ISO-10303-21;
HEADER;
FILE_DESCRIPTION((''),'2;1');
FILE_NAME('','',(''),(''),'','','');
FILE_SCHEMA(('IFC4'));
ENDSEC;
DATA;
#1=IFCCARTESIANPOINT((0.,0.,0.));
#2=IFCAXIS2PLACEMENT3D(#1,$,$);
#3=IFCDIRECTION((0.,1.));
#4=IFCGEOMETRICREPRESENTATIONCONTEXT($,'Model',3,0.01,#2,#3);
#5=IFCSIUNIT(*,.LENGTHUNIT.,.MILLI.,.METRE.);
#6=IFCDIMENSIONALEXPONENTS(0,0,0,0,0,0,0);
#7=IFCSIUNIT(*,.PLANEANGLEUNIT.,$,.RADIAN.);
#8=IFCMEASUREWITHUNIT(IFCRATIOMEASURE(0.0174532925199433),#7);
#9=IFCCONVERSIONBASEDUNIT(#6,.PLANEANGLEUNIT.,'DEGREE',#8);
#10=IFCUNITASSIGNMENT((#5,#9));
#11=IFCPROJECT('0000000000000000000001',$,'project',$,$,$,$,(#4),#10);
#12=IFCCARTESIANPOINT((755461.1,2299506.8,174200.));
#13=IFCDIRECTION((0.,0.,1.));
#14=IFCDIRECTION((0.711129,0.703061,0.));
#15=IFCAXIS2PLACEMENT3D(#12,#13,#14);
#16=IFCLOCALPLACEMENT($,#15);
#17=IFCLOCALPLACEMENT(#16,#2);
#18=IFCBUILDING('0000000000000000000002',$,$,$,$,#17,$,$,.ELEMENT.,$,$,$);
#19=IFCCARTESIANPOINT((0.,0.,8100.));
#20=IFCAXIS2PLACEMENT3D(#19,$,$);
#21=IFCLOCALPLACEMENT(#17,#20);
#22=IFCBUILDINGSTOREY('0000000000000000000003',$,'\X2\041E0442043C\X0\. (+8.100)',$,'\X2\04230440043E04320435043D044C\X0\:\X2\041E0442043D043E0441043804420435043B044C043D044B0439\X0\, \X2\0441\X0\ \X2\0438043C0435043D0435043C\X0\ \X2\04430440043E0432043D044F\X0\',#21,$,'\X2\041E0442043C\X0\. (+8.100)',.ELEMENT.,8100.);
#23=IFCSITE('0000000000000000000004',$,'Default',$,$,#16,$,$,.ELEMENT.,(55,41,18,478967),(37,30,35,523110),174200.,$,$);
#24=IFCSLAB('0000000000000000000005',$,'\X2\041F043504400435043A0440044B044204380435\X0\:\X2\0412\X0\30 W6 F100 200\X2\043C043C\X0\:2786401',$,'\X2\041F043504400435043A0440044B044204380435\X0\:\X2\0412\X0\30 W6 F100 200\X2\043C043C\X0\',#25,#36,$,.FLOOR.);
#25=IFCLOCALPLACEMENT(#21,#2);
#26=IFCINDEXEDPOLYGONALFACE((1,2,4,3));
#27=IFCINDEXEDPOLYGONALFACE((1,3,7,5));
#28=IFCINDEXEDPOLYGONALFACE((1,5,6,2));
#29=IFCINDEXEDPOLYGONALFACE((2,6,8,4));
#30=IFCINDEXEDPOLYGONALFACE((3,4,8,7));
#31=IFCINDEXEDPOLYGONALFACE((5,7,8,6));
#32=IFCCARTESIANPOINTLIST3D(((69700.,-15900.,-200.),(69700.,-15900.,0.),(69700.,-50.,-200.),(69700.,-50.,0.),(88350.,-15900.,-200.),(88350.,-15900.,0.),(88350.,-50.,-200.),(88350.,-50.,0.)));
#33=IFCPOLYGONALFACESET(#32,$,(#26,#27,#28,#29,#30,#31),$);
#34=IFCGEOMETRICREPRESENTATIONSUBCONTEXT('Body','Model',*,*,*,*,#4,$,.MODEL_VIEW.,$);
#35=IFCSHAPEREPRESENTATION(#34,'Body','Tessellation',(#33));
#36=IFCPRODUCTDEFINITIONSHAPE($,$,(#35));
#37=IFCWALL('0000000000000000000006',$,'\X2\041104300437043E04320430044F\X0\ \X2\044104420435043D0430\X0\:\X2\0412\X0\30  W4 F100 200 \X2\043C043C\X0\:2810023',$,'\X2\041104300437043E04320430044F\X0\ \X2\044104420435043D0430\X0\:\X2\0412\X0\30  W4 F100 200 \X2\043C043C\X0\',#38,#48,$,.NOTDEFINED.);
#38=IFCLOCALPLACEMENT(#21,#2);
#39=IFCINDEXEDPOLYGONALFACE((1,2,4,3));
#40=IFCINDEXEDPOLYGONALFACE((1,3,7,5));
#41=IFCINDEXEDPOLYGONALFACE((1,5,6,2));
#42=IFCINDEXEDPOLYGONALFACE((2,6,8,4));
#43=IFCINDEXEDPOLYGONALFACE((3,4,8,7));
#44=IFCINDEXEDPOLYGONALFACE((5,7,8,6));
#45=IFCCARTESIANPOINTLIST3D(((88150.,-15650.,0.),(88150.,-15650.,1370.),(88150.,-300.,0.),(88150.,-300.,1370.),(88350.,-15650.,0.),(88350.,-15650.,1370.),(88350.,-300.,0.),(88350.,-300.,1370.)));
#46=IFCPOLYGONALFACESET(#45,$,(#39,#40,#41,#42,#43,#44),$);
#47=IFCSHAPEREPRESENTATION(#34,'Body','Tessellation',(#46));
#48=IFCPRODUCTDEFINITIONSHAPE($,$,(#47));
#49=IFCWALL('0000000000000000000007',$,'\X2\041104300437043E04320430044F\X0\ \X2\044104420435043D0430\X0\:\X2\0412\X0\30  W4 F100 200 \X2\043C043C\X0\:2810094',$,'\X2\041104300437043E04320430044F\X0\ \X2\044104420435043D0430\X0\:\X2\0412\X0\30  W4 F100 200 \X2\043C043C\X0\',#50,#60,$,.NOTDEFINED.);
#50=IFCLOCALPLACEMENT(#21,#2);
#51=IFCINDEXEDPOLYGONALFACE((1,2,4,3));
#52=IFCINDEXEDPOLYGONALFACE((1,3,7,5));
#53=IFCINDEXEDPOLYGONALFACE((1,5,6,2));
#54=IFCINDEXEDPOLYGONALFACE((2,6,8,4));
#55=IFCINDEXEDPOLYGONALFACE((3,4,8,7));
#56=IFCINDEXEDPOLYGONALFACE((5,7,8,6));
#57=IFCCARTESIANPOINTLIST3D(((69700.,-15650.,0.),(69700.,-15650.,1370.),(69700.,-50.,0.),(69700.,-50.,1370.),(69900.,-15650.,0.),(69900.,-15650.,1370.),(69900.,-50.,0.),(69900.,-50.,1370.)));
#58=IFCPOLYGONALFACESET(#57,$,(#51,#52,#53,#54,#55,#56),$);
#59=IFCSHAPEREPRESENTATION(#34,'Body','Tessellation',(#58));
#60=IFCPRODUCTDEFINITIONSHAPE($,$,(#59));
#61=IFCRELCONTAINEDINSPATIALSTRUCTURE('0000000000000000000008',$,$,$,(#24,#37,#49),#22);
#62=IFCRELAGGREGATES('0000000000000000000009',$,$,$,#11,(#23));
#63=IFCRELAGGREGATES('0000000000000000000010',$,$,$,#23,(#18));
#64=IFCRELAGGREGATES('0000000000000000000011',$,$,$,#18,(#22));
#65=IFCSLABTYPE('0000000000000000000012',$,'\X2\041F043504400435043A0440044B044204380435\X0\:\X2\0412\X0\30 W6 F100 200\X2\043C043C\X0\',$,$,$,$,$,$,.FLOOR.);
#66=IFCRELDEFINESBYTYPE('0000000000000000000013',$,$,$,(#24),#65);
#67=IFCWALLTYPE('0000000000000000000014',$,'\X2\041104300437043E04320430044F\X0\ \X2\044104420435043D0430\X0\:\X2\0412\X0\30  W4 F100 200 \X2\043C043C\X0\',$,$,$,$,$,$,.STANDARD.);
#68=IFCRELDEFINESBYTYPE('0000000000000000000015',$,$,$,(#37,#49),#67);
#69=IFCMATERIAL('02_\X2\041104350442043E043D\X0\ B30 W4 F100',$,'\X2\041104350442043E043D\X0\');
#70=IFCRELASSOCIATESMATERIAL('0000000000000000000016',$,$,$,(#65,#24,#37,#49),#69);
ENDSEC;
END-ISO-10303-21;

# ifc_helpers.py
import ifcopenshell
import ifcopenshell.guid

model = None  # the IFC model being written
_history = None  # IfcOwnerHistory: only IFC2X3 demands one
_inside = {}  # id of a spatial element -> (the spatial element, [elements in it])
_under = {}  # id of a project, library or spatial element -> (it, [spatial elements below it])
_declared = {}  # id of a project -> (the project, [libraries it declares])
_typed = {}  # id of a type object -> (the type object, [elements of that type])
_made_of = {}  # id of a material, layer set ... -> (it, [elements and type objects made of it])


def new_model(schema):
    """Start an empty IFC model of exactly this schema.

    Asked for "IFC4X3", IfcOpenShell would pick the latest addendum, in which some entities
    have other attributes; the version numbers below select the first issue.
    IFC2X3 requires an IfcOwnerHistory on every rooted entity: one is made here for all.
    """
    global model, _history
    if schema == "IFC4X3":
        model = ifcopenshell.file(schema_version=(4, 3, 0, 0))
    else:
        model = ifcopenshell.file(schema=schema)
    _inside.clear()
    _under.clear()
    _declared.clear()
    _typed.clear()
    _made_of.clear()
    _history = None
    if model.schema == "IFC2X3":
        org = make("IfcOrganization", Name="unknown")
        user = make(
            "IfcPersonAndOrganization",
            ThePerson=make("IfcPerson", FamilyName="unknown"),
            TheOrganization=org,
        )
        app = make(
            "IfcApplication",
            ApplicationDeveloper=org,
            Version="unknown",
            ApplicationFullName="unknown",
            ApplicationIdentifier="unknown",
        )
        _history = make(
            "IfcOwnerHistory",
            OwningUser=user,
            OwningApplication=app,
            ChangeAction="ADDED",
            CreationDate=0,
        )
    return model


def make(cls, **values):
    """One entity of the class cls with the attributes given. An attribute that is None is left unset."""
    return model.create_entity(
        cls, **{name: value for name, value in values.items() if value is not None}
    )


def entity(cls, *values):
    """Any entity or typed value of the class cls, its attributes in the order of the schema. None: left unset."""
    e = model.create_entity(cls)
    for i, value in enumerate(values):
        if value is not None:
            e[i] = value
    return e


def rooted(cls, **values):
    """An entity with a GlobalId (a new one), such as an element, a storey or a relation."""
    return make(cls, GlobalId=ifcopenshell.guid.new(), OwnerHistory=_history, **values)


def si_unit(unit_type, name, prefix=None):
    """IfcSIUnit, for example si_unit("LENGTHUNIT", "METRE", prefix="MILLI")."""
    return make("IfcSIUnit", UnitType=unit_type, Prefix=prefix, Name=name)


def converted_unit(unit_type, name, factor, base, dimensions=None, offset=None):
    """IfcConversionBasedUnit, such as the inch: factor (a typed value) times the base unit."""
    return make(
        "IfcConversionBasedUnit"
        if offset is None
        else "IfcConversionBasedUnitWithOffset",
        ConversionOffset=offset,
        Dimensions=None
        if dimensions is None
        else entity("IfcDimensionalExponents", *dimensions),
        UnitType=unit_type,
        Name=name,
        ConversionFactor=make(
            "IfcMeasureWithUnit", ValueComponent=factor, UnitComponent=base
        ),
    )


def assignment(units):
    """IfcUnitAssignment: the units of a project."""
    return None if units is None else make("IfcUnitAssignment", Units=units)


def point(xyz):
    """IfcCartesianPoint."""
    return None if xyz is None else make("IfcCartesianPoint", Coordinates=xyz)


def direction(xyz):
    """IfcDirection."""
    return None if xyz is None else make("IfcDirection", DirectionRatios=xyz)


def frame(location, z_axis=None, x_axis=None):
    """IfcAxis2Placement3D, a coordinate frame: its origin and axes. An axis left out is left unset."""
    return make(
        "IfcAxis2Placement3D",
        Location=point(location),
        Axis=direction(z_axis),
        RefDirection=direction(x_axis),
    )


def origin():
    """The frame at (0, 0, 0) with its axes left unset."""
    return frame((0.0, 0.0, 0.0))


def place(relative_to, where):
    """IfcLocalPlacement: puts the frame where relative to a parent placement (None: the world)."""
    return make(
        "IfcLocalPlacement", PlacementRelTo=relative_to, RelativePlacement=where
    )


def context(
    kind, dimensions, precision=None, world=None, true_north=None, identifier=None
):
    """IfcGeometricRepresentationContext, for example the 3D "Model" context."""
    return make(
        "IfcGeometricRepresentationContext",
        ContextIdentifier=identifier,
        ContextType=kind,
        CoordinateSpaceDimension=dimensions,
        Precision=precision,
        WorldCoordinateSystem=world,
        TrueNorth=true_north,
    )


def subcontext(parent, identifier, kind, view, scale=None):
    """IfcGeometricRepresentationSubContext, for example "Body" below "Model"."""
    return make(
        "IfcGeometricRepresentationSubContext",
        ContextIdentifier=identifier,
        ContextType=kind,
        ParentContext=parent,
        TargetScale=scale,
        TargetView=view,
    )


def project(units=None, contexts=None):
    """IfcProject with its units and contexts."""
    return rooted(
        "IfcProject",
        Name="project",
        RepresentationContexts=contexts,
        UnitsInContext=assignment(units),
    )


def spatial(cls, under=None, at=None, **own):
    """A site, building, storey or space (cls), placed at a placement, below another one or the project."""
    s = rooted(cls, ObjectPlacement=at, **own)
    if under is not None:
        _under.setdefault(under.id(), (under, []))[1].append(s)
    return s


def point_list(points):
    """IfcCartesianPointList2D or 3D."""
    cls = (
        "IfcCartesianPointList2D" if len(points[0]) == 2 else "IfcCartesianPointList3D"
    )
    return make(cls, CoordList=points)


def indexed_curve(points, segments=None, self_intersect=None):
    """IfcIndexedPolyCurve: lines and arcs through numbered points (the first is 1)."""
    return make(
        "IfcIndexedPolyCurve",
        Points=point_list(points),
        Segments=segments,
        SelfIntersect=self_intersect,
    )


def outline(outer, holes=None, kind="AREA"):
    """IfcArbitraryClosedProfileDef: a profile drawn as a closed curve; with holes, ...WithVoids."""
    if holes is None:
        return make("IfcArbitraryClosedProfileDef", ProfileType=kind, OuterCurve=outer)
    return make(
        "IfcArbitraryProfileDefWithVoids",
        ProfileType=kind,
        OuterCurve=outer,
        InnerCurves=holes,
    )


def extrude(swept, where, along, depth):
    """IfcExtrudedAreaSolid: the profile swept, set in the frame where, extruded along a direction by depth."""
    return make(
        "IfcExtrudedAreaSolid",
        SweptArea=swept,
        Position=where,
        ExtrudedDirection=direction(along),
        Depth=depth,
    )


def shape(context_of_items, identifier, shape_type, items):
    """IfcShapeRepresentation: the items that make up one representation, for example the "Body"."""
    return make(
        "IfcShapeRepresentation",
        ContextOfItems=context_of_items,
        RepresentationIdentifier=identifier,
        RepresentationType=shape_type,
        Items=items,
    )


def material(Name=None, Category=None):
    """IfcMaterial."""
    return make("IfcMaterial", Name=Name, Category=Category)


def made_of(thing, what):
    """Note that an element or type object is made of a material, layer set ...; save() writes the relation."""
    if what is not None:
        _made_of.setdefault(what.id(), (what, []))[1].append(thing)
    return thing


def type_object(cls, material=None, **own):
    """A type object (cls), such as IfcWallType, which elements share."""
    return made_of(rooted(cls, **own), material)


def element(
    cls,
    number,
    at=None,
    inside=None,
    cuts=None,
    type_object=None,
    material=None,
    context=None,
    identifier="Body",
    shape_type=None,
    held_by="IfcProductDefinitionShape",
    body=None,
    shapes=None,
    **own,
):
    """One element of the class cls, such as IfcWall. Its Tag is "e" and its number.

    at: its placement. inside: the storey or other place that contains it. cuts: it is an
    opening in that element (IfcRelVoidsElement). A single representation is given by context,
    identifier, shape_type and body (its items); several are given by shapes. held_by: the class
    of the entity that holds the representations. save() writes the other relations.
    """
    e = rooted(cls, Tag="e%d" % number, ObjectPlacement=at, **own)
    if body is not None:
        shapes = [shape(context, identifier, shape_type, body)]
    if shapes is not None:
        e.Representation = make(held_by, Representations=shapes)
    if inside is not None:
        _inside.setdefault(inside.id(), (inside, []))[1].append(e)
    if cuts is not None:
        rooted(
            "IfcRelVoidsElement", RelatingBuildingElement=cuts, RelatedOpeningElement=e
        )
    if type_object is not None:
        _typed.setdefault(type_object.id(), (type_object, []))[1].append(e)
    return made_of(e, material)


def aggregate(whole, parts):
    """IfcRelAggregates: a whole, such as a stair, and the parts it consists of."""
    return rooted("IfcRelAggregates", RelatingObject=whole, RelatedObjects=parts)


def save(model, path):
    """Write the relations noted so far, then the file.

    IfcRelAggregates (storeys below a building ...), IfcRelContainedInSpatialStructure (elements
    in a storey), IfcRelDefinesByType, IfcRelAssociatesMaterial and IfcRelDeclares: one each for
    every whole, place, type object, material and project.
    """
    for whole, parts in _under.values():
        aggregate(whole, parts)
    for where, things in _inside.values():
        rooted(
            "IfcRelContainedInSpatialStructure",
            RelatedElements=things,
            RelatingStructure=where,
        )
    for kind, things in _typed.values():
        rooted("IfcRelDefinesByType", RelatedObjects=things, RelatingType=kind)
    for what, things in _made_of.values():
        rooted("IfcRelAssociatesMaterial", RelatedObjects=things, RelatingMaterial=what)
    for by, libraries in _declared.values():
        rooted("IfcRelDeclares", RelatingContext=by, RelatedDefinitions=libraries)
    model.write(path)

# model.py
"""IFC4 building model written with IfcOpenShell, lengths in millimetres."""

from ifc_helpers import new_model, entity, si_unit, converted_unit, direction, frame, origin, place, context, subcontext, project, spatial, indexed_curve, outline, extrude, material, type_object, element, save


model = new_model("IFC4")

# Units and contexts
model_context = context("Model", 3, precision=0.01, world=origin(), true_north=direction((0.0, 1.0)))
body_context = subcontext(model_context, "Body", "Model", "MODEL_VIEW")
ifc_project = project(units=[si_unit("LENGTHUNIT", "METRE", prefix="MILLI"), converted_unit("PLANEANGLEUNIT", "DEGREE", entity("IfcRatioMeasure", 0.0174532925199433), si_unit("PLANEANGLEUNIT", "RADIAN"), dimensions=[0, 0, 0, 0, 0, 0, 0])], contexts=[model_context])

# Site, building, storey
site_placement = place(None, frame((755461.1, 2299506.8, 174200.0), z_axis=(0.0, 0.0, 1.0), x_axis=(0.711129, 0.703061, 0.0)))
site = spatial("IfcSite", under=ifc_project, at=site_placement, Name="Default", CompositionType="ELEMENT", RefLatitude=(55, 41, 18, 478967), RefLongitude=(37, 30, 35, 523110), RefElevation=174200.0)
building_placement = place(site_placement, origin())
building = spatial("IfcBuilding", under=site, at=building_placement, CompositionType="ELEMENT")
storey_placement = place(building_placement, frame((0.0, 0.0, 8100.0)))
storey = spatial("IfcBuildingStorey", under=building, at=storey_placement, Name="Отм. (+8.100)", ObjectType="Уровень:Относительный, с именем уровня", LongName="Отм. (+8.100)", CompositionType="ELEMENT", Elevation=8100.0)

# Slab
ifc_material_1 = material(Name="02_Бетон B30 W4 F100", Category="Бетон")
slab_type = type_object("IfcSlabType", Name="Перекрытие:В30 W6 F100 200мм", PredefinedType="FLOOR", material=ifc_material_1)
slab_placement = place(storey_placement, origin())
element("IfcSlab", 1, at=slab_placement, inside=storey, type_object=slab_type, material=ifc_material_1, Name="Перекрытие:В30 W6 F100 200мм:2786401", ObjectType="Перекрытие:В30 W6 F100 200мм", PredefinedType="FLOOR", context=body_context, shape_type="SweptSolid", body=[
    extrude(outline(indexed_curve([(-7925.0, -9325.0), (7925.0, -9325.0), (7925.0, 9325.0), (-7925.0, 9325.0), (-7925.0, -9325.0)], self_intersect=False)), frame((79025.0, -7975.0, 0.0), z_axis=(0.0, 0.0, -1.0), x_axis=(0.0, 1.0, 0.0)), (0.0, 0.0, 1.0), 200.0),
])

# Walls
wall_type_1 = type_object("IfcWallType", Name="Базовая стена:В30  W4 F100 200 мм", PredefinedType="STANDARD")
wall_1_placement = place(storey_placement, frame((88250.0, -300.0, 0.0), z_axis=(0.0, 0.0, 1.0), x_axis=(0.0, -1.0, 0.0)))
element("IfcWall", 2, at=wall_1_placement, inside=storey, type_object=wall_type_1, material=ifc_material_1, Name="Базовая стена:В30  W4 F100 200 мм:2810023", ObjectType="Базовая стена:В30  W4 F100 200 мм", PredefinedType="NOTDEFINED", context=body_context, shape_type="SweptSolid", body=[
    extrude(outline(indexed_curve([(15350.0, 100.0), (0.0, 100.0), (0.0, -100.0), (15350.0, -100.0), (15350.0, 100.0)], self_intersect=False)), origin(), (0.0, 0.0, 1.0), 1370.0),
])
wall_2_placement = place(storey_placement, frame((69800.0, -15650.0, 0.0), z_axis=(0.0, 0.0, 1.0), x_axis=(0.0, 1.0, 0.0)))
element("IfcWall", 3, at=wall_2_placement, inside=storey, type_object=wall_type_1, material=ifc_material_1, Name="Базовая стена:В30  W4 F100 200 мм:2810094", ObjectType="Базовая стена:В30  W4 F100 200 мм", PredefinedType="NOTDEFINED", context=body_context, shape_type="SweptSolid", body=[
    extrude(outline(indexed_curve([(15600.0, 100.0), (0.0, 100.0), (0.0, -100.0), (15600.0, -100.0), (15600.0, 100.0)], self_intersect=False)), origin(), (0.0, 0.0, 1.0), 1370.0),
])

save(model, "model.ifc")
